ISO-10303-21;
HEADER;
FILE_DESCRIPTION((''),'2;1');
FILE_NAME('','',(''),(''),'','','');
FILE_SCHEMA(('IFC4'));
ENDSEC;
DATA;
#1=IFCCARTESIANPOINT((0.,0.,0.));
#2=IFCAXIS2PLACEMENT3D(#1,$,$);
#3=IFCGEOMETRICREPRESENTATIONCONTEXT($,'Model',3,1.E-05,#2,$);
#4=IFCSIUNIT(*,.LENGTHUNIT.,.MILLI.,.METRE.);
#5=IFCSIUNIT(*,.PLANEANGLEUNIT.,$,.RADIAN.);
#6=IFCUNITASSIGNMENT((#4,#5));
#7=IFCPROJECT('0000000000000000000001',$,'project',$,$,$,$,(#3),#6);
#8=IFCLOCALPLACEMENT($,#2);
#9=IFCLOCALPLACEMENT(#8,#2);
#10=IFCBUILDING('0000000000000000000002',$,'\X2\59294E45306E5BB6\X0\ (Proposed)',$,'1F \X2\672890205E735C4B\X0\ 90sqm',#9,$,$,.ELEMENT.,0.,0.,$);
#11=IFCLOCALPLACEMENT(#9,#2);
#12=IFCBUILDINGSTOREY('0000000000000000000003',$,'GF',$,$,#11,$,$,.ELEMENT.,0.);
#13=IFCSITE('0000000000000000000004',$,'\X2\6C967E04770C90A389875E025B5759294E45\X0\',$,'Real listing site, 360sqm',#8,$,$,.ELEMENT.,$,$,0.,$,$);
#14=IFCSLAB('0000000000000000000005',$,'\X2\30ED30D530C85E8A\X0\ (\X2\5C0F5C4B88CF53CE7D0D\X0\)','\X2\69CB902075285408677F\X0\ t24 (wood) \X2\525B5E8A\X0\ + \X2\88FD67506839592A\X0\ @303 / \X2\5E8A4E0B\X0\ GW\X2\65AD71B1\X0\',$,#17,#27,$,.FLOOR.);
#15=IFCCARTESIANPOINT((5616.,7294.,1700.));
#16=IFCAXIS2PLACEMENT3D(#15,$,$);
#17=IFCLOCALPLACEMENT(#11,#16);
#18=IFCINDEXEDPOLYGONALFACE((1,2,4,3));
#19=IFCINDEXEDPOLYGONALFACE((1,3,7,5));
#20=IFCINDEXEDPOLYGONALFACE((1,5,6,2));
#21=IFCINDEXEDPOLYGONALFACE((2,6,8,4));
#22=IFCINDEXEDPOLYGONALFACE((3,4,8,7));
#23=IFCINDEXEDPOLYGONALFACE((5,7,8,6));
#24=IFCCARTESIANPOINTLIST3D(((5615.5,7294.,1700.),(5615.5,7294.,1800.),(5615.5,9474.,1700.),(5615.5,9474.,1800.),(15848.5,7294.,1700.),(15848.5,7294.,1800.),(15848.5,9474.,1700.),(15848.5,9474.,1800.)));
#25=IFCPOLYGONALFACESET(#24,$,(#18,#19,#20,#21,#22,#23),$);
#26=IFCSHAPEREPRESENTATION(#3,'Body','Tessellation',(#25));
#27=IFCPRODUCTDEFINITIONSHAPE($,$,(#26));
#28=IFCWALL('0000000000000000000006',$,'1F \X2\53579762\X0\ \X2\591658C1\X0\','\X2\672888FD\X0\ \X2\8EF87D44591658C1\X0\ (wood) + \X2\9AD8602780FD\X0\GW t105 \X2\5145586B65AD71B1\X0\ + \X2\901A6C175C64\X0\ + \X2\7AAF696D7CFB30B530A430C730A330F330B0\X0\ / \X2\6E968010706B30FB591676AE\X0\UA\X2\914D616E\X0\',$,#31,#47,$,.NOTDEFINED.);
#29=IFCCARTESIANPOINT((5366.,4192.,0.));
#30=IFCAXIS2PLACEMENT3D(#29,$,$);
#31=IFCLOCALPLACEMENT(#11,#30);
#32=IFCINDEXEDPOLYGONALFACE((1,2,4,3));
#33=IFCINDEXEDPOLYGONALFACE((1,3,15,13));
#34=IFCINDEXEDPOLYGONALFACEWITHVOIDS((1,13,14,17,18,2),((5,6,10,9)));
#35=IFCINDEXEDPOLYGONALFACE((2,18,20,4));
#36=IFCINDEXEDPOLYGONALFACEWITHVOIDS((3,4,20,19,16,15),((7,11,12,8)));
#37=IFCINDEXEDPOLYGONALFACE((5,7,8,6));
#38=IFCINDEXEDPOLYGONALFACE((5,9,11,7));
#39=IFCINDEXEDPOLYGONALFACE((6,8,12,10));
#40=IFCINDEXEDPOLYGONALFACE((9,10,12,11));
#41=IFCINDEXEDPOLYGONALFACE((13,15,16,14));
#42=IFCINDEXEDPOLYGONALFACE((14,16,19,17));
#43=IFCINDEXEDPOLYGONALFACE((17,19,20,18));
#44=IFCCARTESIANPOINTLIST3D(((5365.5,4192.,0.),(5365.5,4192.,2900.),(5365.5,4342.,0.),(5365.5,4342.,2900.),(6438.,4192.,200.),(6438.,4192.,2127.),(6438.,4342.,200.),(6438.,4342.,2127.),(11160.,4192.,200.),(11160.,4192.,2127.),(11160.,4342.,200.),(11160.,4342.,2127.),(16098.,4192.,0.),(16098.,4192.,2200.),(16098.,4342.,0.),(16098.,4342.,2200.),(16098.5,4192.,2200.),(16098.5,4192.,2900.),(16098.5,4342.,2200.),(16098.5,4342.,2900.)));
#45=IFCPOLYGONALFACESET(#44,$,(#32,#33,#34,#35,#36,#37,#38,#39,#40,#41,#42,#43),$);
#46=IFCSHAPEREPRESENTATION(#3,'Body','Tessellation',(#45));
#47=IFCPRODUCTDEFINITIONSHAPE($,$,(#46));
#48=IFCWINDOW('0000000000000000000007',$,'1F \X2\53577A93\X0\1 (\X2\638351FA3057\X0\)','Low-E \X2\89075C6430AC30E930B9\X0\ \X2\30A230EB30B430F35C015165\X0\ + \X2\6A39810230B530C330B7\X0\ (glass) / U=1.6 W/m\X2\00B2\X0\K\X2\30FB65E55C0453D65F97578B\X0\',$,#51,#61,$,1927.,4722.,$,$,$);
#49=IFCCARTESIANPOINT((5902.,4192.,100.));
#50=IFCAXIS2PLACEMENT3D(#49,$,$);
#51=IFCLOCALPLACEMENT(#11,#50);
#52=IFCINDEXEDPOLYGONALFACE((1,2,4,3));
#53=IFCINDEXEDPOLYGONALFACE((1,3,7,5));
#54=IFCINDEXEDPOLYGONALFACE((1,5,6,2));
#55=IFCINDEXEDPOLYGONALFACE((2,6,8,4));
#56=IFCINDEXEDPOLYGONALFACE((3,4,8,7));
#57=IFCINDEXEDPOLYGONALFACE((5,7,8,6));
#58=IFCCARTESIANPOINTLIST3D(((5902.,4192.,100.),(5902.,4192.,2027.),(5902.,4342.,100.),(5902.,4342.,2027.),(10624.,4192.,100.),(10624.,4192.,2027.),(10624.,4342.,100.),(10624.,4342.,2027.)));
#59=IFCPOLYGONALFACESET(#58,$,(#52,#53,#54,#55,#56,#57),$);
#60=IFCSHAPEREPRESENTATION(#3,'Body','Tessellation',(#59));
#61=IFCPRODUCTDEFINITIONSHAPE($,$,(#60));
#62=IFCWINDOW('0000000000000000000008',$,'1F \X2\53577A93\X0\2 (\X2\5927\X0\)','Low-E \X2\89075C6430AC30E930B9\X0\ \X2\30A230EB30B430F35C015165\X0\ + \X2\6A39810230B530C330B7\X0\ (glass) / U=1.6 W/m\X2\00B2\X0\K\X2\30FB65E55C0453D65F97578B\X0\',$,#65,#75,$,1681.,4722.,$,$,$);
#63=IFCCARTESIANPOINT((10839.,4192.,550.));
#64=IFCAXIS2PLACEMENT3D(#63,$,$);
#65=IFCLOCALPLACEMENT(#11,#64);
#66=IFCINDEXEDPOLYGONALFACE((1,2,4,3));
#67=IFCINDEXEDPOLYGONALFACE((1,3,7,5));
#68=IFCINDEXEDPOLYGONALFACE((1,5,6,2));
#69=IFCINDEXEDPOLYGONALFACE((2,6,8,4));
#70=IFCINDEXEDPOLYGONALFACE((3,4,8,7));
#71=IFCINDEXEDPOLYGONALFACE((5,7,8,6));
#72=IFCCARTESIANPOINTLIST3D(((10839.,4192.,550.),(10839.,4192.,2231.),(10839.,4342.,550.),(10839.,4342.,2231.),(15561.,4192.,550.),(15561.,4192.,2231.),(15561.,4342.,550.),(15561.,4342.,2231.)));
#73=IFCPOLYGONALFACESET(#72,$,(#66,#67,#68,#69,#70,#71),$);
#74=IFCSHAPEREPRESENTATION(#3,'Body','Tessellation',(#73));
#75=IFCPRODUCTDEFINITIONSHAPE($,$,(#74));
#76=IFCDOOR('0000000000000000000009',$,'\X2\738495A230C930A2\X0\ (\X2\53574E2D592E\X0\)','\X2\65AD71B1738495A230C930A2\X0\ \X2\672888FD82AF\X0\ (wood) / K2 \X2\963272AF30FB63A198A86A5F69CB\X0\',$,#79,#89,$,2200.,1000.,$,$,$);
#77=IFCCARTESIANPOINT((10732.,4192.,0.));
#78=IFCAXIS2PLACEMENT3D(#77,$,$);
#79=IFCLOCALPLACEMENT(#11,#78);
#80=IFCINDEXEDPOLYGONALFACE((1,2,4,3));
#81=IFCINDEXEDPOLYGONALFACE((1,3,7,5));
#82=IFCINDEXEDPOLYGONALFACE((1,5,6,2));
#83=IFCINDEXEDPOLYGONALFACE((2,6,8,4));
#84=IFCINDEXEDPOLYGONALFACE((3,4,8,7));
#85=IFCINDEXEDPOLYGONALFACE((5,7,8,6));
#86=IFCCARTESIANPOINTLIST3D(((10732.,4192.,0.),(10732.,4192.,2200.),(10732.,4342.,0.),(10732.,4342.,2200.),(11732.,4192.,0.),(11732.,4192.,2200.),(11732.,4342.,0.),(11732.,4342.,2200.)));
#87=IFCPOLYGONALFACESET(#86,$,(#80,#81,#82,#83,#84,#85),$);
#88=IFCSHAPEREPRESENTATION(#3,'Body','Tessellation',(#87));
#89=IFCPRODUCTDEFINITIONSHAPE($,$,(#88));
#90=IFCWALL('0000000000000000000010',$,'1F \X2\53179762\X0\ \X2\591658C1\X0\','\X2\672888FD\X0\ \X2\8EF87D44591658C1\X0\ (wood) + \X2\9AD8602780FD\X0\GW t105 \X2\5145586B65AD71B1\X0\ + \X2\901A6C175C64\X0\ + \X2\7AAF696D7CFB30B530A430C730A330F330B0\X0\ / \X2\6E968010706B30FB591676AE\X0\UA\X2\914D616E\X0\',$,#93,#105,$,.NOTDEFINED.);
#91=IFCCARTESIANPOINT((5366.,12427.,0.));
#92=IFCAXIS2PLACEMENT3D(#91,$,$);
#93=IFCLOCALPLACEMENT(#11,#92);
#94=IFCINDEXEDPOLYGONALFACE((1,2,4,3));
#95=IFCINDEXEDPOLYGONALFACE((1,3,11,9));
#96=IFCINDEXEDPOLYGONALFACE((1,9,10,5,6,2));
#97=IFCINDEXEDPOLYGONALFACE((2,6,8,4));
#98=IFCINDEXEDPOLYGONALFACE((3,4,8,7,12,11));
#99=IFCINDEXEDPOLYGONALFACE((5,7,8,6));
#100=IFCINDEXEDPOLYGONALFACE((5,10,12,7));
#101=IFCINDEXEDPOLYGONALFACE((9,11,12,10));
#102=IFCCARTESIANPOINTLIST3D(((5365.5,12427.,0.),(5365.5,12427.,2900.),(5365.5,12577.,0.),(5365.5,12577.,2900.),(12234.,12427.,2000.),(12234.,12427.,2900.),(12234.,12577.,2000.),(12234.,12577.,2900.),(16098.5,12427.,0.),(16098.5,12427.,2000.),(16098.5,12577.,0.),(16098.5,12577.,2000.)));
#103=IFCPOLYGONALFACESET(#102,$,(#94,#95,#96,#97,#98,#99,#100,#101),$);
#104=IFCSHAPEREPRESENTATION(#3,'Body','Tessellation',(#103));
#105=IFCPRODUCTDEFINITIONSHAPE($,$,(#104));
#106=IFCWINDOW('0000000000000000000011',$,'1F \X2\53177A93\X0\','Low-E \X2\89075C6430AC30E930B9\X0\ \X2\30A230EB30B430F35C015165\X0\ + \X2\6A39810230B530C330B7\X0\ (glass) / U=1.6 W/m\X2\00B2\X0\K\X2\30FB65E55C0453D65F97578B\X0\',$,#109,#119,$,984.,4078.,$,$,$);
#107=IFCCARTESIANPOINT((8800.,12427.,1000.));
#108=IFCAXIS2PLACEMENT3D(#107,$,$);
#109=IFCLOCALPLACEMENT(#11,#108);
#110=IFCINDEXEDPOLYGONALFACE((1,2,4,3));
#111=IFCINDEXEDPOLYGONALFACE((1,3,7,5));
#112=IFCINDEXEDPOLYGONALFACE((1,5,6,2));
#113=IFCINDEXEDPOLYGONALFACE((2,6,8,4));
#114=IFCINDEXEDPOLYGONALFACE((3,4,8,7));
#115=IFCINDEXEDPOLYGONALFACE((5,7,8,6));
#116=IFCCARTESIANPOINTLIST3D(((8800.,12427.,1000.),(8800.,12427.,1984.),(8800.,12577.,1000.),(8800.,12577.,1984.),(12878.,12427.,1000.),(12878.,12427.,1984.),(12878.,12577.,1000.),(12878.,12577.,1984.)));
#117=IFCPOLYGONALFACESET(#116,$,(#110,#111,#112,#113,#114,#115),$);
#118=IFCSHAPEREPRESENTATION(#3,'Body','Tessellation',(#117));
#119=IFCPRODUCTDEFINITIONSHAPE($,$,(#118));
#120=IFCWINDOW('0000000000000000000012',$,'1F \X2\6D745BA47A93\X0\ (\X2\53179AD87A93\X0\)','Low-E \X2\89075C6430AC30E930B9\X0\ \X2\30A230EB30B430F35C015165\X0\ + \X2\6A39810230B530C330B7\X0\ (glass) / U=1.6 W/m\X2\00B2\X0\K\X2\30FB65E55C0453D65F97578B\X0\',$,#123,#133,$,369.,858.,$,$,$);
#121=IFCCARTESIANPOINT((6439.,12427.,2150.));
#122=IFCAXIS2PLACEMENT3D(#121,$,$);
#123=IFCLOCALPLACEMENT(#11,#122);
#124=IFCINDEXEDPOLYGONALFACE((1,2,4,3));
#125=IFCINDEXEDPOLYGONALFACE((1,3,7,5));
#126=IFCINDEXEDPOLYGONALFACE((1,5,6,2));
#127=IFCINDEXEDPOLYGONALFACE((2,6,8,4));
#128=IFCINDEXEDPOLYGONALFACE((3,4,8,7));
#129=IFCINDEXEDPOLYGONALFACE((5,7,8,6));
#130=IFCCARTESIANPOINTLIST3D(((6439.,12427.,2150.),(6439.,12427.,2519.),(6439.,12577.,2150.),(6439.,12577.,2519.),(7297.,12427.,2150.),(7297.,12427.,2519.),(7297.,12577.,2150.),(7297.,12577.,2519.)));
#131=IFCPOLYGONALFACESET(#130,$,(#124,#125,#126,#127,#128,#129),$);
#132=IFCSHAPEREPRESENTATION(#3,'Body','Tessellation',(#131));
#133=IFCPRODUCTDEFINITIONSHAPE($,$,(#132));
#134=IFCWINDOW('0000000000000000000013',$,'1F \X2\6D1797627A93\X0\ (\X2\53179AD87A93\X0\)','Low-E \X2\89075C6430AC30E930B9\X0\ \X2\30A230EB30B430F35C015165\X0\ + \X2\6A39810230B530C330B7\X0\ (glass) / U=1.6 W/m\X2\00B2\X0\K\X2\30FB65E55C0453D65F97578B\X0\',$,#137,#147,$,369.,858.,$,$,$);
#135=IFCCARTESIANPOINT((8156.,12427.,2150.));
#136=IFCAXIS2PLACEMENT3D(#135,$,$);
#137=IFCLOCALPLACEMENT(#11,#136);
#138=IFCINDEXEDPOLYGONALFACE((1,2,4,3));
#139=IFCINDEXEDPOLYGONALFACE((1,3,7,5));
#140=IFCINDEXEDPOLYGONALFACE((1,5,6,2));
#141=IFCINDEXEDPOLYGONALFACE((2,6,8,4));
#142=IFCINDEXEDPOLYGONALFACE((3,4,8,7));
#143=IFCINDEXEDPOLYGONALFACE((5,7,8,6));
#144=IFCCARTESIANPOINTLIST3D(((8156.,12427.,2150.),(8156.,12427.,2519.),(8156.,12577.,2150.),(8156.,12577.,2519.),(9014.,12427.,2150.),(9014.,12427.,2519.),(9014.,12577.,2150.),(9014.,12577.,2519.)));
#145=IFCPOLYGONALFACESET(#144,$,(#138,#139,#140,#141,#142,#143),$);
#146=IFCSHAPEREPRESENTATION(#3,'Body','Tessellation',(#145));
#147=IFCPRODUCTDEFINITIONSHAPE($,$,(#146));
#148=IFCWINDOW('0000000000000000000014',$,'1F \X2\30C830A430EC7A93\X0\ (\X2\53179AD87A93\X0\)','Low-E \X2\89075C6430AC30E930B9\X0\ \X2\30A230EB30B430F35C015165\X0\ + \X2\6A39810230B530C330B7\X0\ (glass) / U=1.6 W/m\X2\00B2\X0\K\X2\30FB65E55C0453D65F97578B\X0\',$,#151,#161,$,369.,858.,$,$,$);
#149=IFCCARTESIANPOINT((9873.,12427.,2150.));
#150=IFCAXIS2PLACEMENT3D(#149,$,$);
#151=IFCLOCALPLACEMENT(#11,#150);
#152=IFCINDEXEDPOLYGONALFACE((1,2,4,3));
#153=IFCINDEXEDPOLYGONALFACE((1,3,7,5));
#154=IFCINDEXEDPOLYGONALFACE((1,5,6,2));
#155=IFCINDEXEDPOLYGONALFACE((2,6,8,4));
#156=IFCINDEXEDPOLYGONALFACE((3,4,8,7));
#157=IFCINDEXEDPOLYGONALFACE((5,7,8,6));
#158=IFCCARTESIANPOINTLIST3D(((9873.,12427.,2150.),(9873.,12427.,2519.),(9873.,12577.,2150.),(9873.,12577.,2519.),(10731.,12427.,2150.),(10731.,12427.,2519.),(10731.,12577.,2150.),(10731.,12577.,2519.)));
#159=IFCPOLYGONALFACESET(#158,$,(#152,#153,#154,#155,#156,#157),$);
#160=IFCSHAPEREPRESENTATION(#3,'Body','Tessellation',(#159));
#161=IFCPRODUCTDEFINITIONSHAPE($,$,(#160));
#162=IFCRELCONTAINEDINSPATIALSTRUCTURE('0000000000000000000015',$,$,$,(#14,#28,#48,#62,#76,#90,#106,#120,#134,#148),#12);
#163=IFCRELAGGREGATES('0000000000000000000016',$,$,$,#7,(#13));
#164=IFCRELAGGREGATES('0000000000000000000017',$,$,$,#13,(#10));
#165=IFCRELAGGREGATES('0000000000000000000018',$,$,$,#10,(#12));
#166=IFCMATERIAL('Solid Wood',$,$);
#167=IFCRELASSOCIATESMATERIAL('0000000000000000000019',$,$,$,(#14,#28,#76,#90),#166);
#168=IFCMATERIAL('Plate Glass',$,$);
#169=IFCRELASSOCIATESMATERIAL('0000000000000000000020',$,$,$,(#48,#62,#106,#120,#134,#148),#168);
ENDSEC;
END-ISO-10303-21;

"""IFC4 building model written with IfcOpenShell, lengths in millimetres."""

from ifc_helpers import new_model, si_unit, frame, frame_2d, origin, place, context, project, spatial, rectangle, extrude, material, element, fill, save


model = new_model("IFC4")

# Units and contexts
model_context = context("Model", 3, precision=1e-05, world=origin())
ifc_project = project(units=[si_unit("LENGTHUNIT", "METRE", prefix="MILLI"), si_unit("PLANEANGLEUNIT", "RADIAN")], contexts=[model_context])

# Site, building, storey
site_placement = place(None, origin())
site = spatial("IfcSite", under=ifc_project, at=site_placement, Name="沖縄県那覇市字天久", ObjectType="Real listing site, 360sqm", CompositionType="ELEMENT", RefElevation=0.0)
building_placement = place(site_placement, origin())
building = spatial("IfcBuilding", under=site, at=building_placement, Name="天久の家 (Proposed)", ObjectType="1F 木造平屋 90sqm", CompositionType="ELEMENT", ElevationOfRefHeight=0.0, ElevationOfTerrain=0.0)
storey_placement = place(building_placement, origin())
storey = spatial("IfcBuildingStorey", under=building, at=storey_placement, Name="GF", CompositionType="ELEMENT", Elevation=0.0)

# Slab
ifc_material_1 = material(Name="Solid Wood")
slab_1_placement = place(storey_placement, frame((5616.0, 7294.0, 1700.0)))
element("IfcSlab", 1, at=slab_1_placement, inside=storey, material=ifc_material_1, Name="ロフト床 (小屋裏収納)", Description="構造用合板 t24 (wood) 剛床 + 製材根太 @303 / 床下 GW断熱", PredefinedType="FLOOR", context=model_context, shape_type="SweptSolid", body=[
    extrude(rectangle(XDim=10233.0, YDim=2180.0, at=frame_2d((5116.0, 1090.0))), frame((5616.0, 7294.0, 1700.0)), (0.0, 0.0, 1.0), 100.0),
])

# Wall, openings, windows, door
wall_1_placement = place(storey_placement, frame((5366.0, 4192.0, 0.0)))
wall_1 = element("IfcWall", 2, at=wall_1_placement, inside=storey, material=ifc_material_1, Name="1F 南面 外壁", Description="木製 軸組外壁 (wood) + 高性能GW t105 充填断熱 + 通気層 + 窯業系サイディング / 準耐火・外皮UA配慮", PredefinedType="NOTDEFINED", context=model_context, shape_type="SweptSolid", body=[
    extrude(rectangle(XDim=10733.0, YDim=150.0, at=frame_2d((5366.0, 75.0))), frame((5366.0, 4192.0, 0.0)), (0.0, 0.0, 1.0), 2900.0),
])
opening_1_placement = place(storey_placement, frame((5902.0, 4192.0, 100.0)))
opening_1 = element("IfcOpeningElement", 3, at=opening_1_placement, cuts=wall_1, PredefinedType="NOTDEFINED", context=model_context, shape_type="SweptSolid", body=[
    extrude(rectangle(XDim=4722.0, YDim=150.0, at=frame_2d((2361.0, 75.0))), frame((5902.0, 4192.0, 100.0)), (0.0, 0.0, 1.0), 1927.0),
])
opening_2_placement = place(storey_placement, frame((10839.0, 4192.0, 550.0)))
opening_2 = element("IfcOpeningElement", 4, at=opening_2_placement, cuts=wall_1, PredefinedType="NOTDEFINED", context=model_context, shape_type="SweptSolid", body=[
    extrude(rectangle(XDim=4722.0, YDim=150.0, at=frame_2d((2361.0, 75.0))), frame((10839.0, 4192.0, 550.0)), (0.0, 0.0, 1.0), 1681.0),
])
opening_3_placement = place(storey_placement, frame((10732.0, 4192.0, 0.0)))
opening_3 = element("IfcOpeningElement", 5, at=opening_3_placement, cuts=wall_1, PredefinedType="NOTDEFINED", context=model_context, shape_type="SweptSolid", body=[
    extrude(rectangle(XDim=1000.0, YDim=150.0, at=frame_2d((500.0, 75.0))), frame((10732.0, 4192.0, 0.0)), (0.0, 0.0, 1.0), 2200.0),
])
ifc_material_2 = material(Name="Plate Glass")
window_1_placement = place(storey_placement, frame((5902.0, 4192.0, 100.0)))
window_1 = element("IfcWindow", 6, at=window_1_placement, inside=storey, material=ifc_material_2, Name="1F 南窓1 (掃出し)", Description="Low-E 複層ガラス アルゴン封入 + 樹脂サッシ (glass) / U=1.6 W/m²K・日射取得型", OverallHeight=1927.0, OverallWidth=4722.0, context=model_context, shape_type="SweptSolid", body=[
    extrude(rectangle(XDim=4722.0, YDim=150.0, at=frame_2d((2361.0, 75.0))), frame((5902.0, 4192.0, 100.0)), (0.0, 0.0, 1.0), 1927.0),
])
fill(opening_1, window_1)
window_2_placement = place(storey_placement, frame((10839.0, 4192.0, 550.0)))
window_2 = element("IfcWindow", 7, at=window_2_placement, inside=storey, material=ifc_material_2, Name="1F 南窓2 (大)", Description="Low-E 複層ガラス アルゴン封入 + 樹脂サッシ (glass) / U=1.6 W/m²K・日射取得型", OverallHeight=1681.0, OverallWidth=4722.0, context=model_context, shape_type="SweptSolid", body=[
    extrude(rectangle(XDim=4722.0, YDim=150.0, at=frame_2d((2361.0, 75.0))), frame((10839.0, 4192.0, 550.0)), (0.0, 0.0, 1.0), 1681.0),
])
fill(opening_2, window_2)
door_1_placement = place(storey_placement, frame((10732.0, 4192.0, 0.0)))
door_1 = element("IfcDoor", 8, at=door_1_placement, inside=storey, material=ifc_material_1, Name="玄関ドア (南中央)", Description="断熱玄関ドア 木製芯 (wood) / K2 防犯・採風機構", OverallHeight=2200.0, OverallWidth=1000.0, context=model_context, shape_type="SweptSolid", body=[
    extrude(rectangle(XDim=1000.0, YDim=150.0, at=frame_2d((500.0, 75.0))), frame((10732.0, 4192.0, 0.0)), (0.0, 0.0, 1.0), 2200.0),
])
fill(opening_3, door_1)

# Wall, openings, windows
wall_2_placement = place(storey_placement, frame((5366.0, 12427.0, 0.0)))
wall_2 = element("IfcWall", 9, at=wall_2_placement, inside=storey, material=ifc_material_1, Name="1F 北面 外壁", Description="木製 軸組外壁 (wood) + 高性能GW t105 充填断熱 + 通気層 + 窯業系サイディング / 準耐火・外皮UA配慮", PredefinedType="NOTDEFINED", context=model_context, shape_type="SweptSolid", body=[
    extrude(rectangle(XDim=10733.0, YDim=150.0, at=frame_2d((5366.0, 75.0))), frame((5366.0, 12427.0, 0.0)), (0.0, 0.0, 1.0), 2900.0),
])
opening_4_placement = place(storey_placement, frame((8800.0, 12427.0, 1000.0)))
opening_4 = element("IfcOpeningElement", 10, at=opening_4_placement, cuts=wall_2, PredefinedType="NOTDEFINED", context=model_context, shape_type="SweptSolid", body=[
    extrude(rectangle(XDim=4078.0, YDim=150.0, at=frame_2d((2039.0, 75.0))), frame((8800.0, 12427.0, 1000.0)), (0.0, 0.0, 1.0), 984.0),
])
opening_5_placement = place(storey_placement, frame((6439.0, 12427.0, 2150.0)))
opening_5 = element("IfcOpeningElement", 11, at=opening_5_placement, cuts=wall_2, PredefinedType="NOTDEFINED", context=model_context, shape_type="SweptSolid", body=[
    extrude(rectangle(XDim=858.0, YDim=150.0, at=frame_2d((429.0, 75.0))), frame((6439.0, 12427.0, 2150.0)), (0.0, 0.0, 1.0), 369.0),
])
opening_6_placement = place(storey_placement, frame((8156.0, 12427.0, 2150.0)))
opening_6 = element("IfcOpeningElement", 12, at=opening_6_placement, cuts=wall_2, PredefinedType="NOTDEFINED", context=model_context, shape_type="SweptSolid", body=[
    extrude(rectangle(XDim=858.0, YDim=150.0, at=frame_2d((429.0, 75.0))), frame((8156.0, 12427.0, 2150.0)), (0.0, 0.0, 1.0), 369.0),
])
opening_7_placement = place(storey_placement, frame((9873.0, 12427.0, 2150.0)))
opening_7 = element("IfcOpeningElement", 13, at=opening_7_placement, cuts=wall_2, PredefinedType="NOTDEFINED", context=model_context, shape_type="SweptSolid", body=[
    extrude(rectangle(XDim=858.0, YDim=150.0, at=frame_2d((429.0, 75.0))), frame((9873.0, 12427.0, 2150.0)), (0.0, 0.0, 1.0), 369.0),
])
window_3_placement = place(storey_placement, frame((8800.0, 12427.0, 1000.0)))
window_3 = element("IfcWindow", 14, at=window_3_placement, inside=storey, material=ifc_material_2, Name="1F 北窓", Description="Low-E 複層ガラス アルゴン封入 + 樹脂サッシ (glass) / U=1.6 W/m²K・日射取得型", OverallHeight=984.0, OverallWidth=4078.0, context=model_context, shape_type="SweptSolid", body=[
    extrude(rectangle(XDim=4078.0, YDim=150.0, at=frame_2d((2039.0, 75.0))), frame((8800.0, 12427.0, 1000.0)), (0.0, 0.0, 1.0), 984.0),
])
fill(opening_4, window_3)
window_4_placement = place(storey_placement, frame((6439.0, 12427.0, 2150.0)))
window_4 = element("IfcWindow", 15, at=window_4_placement, inside=storey, material=ifc_material_2, Name="1F 浴室窓 (北高窓)", Description="Low-E 複層ガラス アルゴン封入 + 樹脂サッシ (glass) / U=1.6 W/m²K・日射取得型", OverallHeight=369.0, OverallWidth=858.0, context=model_context, shape_type="SweptSolid", body=[
    extrude(rectangle(XDim=858.0, YDim=150.0, at=frame_2d((429.0, 75.0))), frame((6439.0, 12427.0, 2150.0)), (0.0, 0.0, 1.0), 369.0),
])
fill(opening_5, window_4)
window_5_placement = place(storey_placement, frame((8156.0, 12427.0, 2150.0)))
window_5 = element("IfcWindow", 16, at=window_5_placement, inside=storey, material=ifc_material_2, Name="1F 洗面窓 (北高窓)", Description="Low-E 複層ガラス アルゴン封入 + 樹脂サッシ (glass) / U=1.6 W/m²K・日射取得型", OverallHeight=369.0, OverallWidth=858.0, context=model_context, shape_type="SweptSolid", body=[
    extrude(rectangle(XDim=858.0, YDim=150.0, at=frame_2d((429.0, 75.0))), frame((8156.0, 12427.0, 2150.0)), (0.0, 0.0, 1.0), 369.0),
])
fill(opening_6, window_5)
window_6_placement = place(storey_placement, frame((9873.0, 12427.0, 2150.0)))
window_6 = element("IfcWindow", 17, at=window_6_placement, inside=storey, material=ifc_material_2, Name="1F トイレ窓 (北高窓)", Description="Low-E 複層ガラス アルゴン封入 + 樹脂サッシ (glass) / U=1.6 W/m²K・日射取得型", OverallHeight=369.0, OverallWidth=858.0, context=model_context, shape_type="SweptSolid", body=[
    extrude(rectangle(XDim=858.0, YDim=150.0, at=frame_2d((429.0, 75.0))), frame((9873.0, 12427.0, 2150.0)), (0.0, 0.0, 1.0), 369.0),
])
fill(opening_7, window_6)

save(model, "model.ifc")
